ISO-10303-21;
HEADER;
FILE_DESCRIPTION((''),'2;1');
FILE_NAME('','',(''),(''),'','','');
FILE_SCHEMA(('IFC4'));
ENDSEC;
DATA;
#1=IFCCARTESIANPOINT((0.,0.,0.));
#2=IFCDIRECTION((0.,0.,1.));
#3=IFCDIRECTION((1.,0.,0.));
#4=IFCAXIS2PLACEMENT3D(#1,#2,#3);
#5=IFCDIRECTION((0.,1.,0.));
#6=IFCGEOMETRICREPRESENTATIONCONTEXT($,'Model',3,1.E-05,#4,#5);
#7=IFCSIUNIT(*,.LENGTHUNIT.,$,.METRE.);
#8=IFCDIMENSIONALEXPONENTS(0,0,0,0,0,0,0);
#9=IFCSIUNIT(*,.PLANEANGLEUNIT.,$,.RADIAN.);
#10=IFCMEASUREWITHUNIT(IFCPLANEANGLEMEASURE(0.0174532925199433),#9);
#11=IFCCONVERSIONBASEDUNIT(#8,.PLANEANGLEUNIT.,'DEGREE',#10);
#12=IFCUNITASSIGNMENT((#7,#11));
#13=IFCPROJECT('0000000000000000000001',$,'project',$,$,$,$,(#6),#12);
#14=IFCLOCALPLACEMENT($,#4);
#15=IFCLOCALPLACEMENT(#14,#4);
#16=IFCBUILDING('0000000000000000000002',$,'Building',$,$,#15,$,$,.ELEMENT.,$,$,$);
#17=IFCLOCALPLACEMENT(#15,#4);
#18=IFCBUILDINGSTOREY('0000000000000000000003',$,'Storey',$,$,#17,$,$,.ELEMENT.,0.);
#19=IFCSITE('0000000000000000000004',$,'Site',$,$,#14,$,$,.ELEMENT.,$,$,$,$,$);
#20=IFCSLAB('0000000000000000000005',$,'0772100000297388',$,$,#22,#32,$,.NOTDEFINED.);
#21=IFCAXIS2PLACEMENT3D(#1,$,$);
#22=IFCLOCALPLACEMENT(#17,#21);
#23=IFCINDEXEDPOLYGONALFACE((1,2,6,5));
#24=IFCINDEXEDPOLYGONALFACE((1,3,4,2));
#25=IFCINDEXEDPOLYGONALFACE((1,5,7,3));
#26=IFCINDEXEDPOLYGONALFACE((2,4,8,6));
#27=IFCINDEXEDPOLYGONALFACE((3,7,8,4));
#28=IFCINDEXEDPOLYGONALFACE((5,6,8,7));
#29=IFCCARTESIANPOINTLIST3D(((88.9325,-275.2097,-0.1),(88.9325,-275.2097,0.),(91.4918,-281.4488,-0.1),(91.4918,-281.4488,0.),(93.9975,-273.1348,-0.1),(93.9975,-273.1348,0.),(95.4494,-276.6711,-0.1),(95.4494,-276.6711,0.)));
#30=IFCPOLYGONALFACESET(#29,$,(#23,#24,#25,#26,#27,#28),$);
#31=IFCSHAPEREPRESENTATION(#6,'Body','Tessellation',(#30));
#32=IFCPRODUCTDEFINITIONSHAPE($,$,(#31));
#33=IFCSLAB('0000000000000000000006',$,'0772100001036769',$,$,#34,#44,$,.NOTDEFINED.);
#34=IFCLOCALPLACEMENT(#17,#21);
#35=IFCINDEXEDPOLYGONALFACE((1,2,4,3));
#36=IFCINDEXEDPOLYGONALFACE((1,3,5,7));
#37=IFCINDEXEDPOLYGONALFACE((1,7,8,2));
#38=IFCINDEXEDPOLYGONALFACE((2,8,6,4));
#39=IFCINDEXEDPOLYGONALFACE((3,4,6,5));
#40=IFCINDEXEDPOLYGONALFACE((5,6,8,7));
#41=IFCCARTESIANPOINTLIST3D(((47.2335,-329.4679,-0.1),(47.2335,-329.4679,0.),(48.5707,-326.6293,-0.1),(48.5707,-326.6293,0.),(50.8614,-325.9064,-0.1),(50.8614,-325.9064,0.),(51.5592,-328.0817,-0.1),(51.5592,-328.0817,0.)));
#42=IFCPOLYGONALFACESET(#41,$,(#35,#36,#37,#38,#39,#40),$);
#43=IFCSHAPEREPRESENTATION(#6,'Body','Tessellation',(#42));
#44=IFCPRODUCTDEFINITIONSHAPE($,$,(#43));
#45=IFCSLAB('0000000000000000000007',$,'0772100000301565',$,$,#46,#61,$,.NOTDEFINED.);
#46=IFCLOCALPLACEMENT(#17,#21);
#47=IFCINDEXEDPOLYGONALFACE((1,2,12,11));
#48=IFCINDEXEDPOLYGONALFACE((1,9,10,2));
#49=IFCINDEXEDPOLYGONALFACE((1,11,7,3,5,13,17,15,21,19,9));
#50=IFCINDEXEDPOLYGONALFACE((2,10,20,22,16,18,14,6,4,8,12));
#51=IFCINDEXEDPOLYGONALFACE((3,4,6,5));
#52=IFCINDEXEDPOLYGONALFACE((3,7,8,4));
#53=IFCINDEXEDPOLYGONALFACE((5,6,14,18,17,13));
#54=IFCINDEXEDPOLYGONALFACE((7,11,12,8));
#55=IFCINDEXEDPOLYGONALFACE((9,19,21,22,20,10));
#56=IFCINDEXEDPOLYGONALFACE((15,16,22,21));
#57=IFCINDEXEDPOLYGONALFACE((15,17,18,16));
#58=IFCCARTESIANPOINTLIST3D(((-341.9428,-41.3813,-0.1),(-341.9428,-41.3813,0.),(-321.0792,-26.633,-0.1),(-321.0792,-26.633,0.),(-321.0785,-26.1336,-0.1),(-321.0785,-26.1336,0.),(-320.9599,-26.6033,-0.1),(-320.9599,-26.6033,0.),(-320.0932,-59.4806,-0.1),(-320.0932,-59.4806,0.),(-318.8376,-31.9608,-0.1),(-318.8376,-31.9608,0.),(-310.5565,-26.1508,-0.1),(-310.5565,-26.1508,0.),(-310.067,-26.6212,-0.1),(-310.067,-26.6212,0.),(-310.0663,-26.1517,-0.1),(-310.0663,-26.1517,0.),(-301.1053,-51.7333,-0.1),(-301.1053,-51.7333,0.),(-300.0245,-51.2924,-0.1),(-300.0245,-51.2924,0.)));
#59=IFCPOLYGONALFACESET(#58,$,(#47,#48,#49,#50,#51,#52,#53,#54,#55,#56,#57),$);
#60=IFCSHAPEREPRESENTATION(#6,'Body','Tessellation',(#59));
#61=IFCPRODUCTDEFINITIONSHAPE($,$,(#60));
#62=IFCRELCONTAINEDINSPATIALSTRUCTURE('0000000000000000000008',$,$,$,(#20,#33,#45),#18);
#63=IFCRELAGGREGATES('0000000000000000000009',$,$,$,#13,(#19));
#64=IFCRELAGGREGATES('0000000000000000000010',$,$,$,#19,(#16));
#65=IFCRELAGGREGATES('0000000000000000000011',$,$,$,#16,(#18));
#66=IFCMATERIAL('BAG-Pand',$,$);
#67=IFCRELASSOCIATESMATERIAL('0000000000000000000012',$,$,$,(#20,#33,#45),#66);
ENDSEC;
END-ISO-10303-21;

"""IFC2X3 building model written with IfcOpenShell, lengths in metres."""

from ifc_helpers import new_model, entity, si_unit, converted_unit, direction, frame, origin_with_axes, place, context, project, spatial, polyline, outline, extrude, material, element, save


model = new_model("IFC2X3")

# Units and contexts
model_context = context("Model", 3, precision=1e-05, world=origin_with_axes(), true_north=direction((0.0, 1.0, 0.0)))
ifc_project = project(units=[si_unit("LENGTHUNIT", "METRE"), converted_unit("PLANEANGLEUNIT", "DEGREE", entity("IfcPlaneAngleMeasure", 0.0174532925199433), si_unit("PLANEANGLEUNIT", "RADIAN"), dimensions=[0, 0, 0, 0, 0, 0, 0])], contexts=[model_context])

# Site, building, storey
site_placement = place(None, origin_with_axes())
site = spatial("IfcSite", under=ifc_project, at=site_placement, Name="Site", CompositionType="ELEMENT")
building_placement = place(site_placement, origin_with_axes())
building = spatial("IfcBuilding", under=site, at=building_placement, Name="Building", CompositionType="ELEMENT")
storey_placement = place(building_placement, origin_with_axes())
storey = spatial("IfcBuildingStorey", under=building, at=storey_placement, Name="Storey", CompositionType="ELEMENT", Elevation=0.0)

# Slabs
ifc_material = material(Name="BAG-Pand")
slab_1_placement = place(storey_placement, frame((0.0, 0.0, -0.1), z_axis=(0.0, 0.0, 1.0), x_axis=(1.0, 0.0, 0.0)))
element("IfcSlab", 1, at=slab_1_placement, inside=storey, material=ifc_material, Name="0772100000297388", PredefinedType="NOTDEFINED", context=model_context, shape_type="SweptSolid", body=[
    extrude(outline(polyline([(88.9325, -275.2097), (93.9975, -273.1348), (95.4494, -276.6711), (91.4918, -281.4488), (88.9325, -275.2097)])), origin_with_axes(), (0.0, 0.0, 1.0), 0.1),
])
slab_2_placement = place(storey_placement, frame((0.0, 0.0, -0.1), z_axis=(0.0, 0.0, 1.0), x_axis=(1.0, 0.0, 0.0)))
element("IfcSlab", 2, at=slab_2_placement, inside=storey, material=ifc_material, Name="0772100001036769", PredefinedType="NOTDEFINED", context=model_context, shape_type="SweptSolid", body=[
    extrude(outline(polyline([(48.5707, -326.6293), (50.8614, -325.9064), (51.5592, -328.0817), (47.2335, -329.4679), (48.5707, -326.6293)])), origin_with_axes(), (0.0, 0.0, 1.0), 0.1),
])
slab_3_placement = place(storey_placement, frame((0.0, 0.0, -0.1), z_axis=(0.0, 0.0, 1.0), x_axis=(1.0, 0.0, 0.0)))
element("IfcSlab", 3, at=slab_3_placement, inside=storey, material=ifc_material, Name="0772100000301565", PredefinedType="NOTDEFINED", context=model_context, shape_type="SweptSolid", body=[
    extrude(outline(polyline([(-318.8376, -31.9608), (-320.9599, -26.6033), (-321.0792, -26.633), (-321.0785, -26.1336), (-310.5565, -26.1508), (-310.0663, -26.1517), (-310.067, -26.6212), (-300.0245, -51.2924), (-301.1053, -51.7333), (-320.0932, -59.4806), (-341.9428, -41.3813), (-318.8376, -31.9608)])), origin_with_axes(), (0.0, 0.0, 1.0), 0.1),
])

save(model, "model.ifc")
